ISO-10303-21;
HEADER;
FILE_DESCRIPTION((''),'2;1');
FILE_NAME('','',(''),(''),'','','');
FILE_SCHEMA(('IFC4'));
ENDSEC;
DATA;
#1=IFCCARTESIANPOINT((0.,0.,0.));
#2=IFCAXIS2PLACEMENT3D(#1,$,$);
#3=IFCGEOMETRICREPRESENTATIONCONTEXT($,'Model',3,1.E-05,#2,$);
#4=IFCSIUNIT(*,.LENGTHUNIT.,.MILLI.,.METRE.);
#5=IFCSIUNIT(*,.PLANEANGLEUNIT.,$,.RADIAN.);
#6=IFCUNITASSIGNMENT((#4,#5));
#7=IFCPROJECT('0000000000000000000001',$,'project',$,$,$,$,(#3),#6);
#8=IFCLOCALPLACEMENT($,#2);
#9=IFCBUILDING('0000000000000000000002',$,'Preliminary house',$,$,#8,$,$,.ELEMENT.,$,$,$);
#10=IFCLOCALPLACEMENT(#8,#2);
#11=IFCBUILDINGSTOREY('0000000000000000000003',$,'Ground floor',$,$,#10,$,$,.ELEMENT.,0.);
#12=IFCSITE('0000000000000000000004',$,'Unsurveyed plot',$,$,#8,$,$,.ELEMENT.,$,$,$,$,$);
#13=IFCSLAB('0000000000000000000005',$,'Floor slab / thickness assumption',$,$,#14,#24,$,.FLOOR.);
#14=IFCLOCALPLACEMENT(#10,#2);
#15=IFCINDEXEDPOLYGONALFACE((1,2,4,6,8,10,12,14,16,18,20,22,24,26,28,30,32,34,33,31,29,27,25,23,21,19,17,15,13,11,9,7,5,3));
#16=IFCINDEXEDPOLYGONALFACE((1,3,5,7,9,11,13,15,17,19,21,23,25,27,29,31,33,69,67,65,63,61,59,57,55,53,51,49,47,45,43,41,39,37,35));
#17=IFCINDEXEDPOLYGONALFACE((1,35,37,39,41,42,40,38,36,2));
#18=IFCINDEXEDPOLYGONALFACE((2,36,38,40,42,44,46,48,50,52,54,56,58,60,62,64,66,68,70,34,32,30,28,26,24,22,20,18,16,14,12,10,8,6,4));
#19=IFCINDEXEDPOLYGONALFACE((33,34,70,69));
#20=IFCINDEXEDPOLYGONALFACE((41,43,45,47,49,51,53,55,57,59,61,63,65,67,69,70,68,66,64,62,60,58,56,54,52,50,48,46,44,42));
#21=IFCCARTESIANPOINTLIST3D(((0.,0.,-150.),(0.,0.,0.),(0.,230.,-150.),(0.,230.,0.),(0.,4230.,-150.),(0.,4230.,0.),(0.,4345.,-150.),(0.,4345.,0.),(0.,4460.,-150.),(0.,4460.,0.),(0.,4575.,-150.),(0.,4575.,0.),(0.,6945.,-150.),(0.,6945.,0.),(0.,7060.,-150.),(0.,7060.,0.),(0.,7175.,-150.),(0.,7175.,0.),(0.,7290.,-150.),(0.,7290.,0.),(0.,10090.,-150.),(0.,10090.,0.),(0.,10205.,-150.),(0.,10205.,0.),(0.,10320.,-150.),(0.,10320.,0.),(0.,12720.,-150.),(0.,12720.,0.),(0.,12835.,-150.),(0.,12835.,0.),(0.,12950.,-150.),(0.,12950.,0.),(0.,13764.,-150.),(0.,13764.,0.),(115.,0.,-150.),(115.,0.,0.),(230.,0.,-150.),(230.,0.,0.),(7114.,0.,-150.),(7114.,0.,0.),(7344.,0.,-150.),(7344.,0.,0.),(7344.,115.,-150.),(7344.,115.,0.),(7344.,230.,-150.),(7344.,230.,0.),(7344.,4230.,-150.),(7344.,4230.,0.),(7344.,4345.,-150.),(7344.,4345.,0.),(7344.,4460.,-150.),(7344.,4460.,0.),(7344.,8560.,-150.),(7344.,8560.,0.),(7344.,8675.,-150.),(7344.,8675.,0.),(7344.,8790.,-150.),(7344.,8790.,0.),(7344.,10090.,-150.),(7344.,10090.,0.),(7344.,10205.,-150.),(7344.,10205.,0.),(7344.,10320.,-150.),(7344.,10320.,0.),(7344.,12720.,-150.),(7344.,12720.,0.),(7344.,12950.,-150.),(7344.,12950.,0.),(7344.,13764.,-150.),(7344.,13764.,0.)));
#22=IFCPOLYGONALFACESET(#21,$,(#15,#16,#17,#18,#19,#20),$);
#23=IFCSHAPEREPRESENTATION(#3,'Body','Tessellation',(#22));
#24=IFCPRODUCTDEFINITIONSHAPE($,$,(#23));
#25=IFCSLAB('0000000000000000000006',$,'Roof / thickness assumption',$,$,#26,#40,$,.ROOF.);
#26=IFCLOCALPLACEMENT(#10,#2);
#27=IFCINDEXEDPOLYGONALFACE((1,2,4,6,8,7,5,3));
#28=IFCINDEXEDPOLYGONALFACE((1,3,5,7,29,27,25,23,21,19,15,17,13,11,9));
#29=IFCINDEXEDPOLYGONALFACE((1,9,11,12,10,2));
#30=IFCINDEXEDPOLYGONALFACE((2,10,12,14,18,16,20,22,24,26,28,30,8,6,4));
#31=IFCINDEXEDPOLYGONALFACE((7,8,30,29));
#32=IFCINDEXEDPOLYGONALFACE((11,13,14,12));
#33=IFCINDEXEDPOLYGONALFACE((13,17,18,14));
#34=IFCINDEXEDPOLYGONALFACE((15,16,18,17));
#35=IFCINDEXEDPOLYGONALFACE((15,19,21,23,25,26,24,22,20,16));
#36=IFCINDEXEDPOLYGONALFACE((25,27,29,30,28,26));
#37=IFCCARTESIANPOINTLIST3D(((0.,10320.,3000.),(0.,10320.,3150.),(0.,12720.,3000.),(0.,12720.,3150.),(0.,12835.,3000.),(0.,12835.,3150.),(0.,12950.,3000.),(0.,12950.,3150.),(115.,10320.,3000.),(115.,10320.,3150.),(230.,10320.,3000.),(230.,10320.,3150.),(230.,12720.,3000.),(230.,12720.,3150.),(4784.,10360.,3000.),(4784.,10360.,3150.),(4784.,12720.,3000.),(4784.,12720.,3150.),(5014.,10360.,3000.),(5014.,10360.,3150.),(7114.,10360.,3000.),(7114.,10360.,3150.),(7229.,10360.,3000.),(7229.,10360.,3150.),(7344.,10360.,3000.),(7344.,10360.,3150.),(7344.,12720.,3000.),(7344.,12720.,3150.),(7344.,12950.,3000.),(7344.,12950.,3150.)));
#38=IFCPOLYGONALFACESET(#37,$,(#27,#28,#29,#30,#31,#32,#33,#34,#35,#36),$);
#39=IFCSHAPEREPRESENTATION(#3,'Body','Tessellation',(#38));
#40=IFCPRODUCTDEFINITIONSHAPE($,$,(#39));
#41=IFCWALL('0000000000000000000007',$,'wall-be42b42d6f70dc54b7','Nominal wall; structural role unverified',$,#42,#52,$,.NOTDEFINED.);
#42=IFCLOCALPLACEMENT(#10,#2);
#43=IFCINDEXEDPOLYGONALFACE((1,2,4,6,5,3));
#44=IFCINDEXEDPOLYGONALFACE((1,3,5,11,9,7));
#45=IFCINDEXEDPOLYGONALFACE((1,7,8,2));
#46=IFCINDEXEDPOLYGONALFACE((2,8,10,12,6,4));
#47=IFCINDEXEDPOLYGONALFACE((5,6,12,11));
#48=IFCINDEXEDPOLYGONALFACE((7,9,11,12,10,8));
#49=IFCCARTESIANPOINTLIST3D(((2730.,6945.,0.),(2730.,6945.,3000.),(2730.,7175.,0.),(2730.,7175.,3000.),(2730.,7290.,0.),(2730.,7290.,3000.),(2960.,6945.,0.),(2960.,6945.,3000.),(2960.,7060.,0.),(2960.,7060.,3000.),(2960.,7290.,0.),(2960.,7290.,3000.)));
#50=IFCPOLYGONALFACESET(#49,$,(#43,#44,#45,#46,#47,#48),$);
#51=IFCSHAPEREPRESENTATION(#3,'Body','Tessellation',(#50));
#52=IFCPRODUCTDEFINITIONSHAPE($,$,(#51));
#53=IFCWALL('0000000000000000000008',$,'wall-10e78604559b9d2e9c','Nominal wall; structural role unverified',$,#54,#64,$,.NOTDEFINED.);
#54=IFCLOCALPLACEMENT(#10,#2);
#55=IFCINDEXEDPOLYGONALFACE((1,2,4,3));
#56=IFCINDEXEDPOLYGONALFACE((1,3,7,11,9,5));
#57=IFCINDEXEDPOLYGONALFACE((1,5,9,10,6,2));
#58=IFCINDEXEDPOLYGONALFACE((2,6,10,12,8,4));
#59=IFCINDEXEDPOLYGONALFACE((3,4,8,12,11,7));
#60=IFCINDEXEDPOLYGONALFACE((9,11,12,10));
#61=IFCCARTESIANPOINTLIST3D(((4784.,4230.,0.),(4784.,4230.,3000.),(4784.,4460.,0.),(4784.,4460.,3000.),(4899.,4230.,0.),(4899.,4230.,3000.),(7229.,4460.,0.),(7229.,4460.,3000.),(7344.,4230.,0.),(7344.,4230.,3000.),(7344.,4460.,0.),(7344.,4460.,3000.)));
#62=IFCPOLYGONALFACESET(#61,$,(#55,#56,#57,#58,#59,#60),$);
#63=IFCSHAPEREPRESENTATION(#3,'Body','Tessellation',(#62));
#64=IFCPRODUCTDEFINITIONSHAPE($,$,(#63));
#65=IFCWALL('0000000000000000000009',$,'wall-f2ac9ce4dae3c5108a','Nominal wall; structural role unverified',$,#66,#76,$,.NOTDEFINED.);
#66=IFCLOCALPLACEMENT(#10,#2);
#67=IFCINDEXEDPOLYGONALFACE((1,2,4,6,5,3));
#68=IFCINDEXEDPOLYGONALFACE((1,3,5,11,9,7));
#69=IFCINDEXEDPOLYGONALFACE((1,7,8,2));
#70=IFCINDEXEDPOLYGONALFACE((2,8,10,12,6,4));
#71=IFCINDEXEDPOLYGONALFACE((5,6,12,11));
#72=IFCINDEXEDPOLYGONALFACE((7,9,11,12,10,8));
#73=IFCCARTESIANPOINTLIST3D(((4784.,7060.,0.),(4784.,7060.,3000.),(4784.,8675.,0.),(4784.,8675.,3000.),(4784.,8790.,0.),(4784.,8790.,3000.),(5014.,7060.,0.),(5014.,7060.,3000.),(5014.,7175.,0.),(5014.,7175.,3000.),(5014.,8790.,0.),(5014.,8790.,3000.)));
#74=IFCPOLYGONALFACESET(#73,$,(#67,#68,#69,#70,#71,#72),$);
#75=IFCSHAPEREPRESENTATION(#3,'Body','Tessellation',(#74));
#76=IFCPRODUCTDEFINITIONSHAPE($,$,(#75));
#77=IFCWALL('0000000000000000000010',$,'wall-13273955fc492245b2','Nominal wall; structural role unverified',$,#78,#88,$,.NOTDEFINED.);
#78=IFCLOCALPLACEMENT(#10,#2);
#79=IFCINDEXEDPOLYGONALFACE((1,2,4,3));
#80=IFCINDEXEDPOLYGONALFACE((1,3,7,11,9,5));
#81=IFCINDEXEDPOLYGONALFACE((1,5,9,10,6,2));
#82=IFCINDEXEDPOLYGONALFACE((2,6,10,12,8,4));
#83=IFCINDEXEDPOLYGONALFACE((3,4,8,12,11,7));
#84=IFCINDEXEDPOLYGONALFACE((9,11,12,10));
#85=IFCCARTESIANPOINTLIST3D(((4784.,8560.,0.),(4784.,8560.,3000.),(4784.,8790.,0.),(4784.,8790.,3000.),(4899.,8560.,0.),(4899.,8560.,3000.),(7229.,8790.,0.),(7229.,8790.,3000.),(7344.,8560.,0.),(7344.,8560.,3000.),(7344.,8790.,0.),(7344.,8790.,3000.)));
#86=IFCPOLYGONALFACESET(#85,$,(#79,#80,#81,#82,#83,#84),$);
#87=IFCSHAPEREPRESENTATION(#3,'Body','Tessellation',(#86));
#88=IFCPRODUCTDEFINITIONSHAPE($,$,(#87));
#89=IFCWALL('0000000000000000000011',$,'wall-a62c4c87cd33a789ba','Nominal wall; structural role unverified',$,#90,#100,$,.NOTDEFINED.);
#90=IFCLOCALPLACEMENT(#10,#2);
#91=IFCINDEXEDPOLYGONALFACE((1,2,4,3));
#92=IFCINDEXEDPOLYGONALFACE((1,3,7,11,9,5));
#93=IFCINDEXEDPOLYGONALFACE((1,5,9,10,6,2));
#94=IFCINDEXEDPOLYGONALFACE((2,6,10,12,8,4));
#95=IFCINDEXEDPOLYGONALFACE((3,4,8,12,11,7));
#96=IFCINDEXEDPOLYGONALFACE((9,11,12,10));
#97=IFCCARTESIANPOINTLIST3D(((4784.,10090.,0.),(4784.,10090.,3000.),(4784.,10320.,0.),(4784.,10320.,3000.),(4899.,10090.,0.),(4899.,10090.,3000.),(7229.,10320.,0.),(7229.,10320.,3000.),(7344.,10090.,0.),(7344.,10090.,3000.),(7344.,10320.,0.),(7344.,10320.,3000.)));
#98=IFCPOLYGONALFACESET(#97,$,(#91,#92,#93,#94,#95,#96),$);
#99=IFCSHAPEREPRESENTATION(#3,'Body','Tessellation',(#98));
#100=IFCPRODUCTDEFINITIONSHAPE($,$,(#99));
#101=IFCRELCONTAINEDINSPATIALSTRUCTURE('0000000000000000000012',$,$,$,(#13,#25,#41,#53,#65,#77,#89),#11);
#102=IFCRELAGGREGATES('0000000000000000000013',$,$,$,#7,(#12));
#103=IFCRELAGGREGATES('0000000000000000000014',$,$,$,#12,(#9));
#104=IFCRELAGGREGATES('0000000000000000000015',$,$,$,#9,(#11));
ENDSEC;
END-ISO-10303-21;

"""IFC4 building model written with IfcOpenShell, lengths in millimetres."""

from ifc_helpers import new_model, si_unit, frame, origin, place, context, project, spatial, polyline, outline, extrude, element, save


model = new_model("IFC4")

# Units and contexts
model_context = context("Model", 3, precision=1e-05, world=origin())
ifc_project = project(units=[si_unit("LENGTHUNIT", "METRE", prefix="MILLI"), si_unit("PLANEANGLEUNIT", "RADIAN")], contexts=[model_context])

# Site, building, storey
placement_1 = place(None, origin())
site = spatial("IfcSite", under=ifc_project, at=placement_1, Name="Unsurveyed plot", CompositionType="ELEMENT")
building = spatial("IfcBuilding", under=site, at=placement_1, Name="Preliminary house", CompositionType="ELEMENT")
placement_2 = place(placement_1, origin())
storey = spatial("IfcBuildingStorey", under=building, at=placement_2, Name="Ground floor", CompositionType="ELEMENT", Elevation=0.0)

# Slabs
element("IfcSlab", 1, at=placement_2, inside=storey, Name="Floor slab / thickness assumption", PredefinedType="FLOOR", context=model_context, shape_type="SweptSolid", body=[
    extrude(outline(polyline([(0.0, 0.0), (0.0, 230.0), (0.0, 4230.0), (0.0, 4345.0), (0.0, 4460.0), (0.0, 4575.0), (0.0, 6945.0), (0.0, 7060.0), (0.0, 7175.0), (0.0, 7290.0), (0.0, 10090.0), (0.0, 10205.0), (0.0, 10320.0), (0.0, 12720.0), (0.0, 12835.0), (0.0, 12950.0), (0.0, 13764.0), (7344.0, 13764.0), (7344.0, 12950.0), (7344.0, 12720.0), (7344.0, 10320.0), (7344.0, 10205.0), (7344.0, 10090.0), (7344.0, 8790.0), (7344.0, 8675.0), (7344.0, 8560.0), (7344.0, 4460.0), (7344.0, 4345.0), (7344.0, 4230.0), (7344.0, 230.0), (7344.0, 115.0), (7344.0, 0.0), (7114.0, 0.0), (230.0, 0.0), (115.0, 0.0), (0.0, 0.0)])), frame((0.0, 0.0, -150.0)), (0.0, 0.0, 1.0), 150.0),
])
element("IfcSlab", 2, at=placement_2, inside=storey, Name="Roof / thickness assumption", PredefinedType="ROOF", context=model_context, shape_type="SweptSolid", body=[
    extrude(outline(polyline([(0.0, 12720.0), (0.0, 12835.0), (0.0, 12950.0), (7344.0, 12950.0), (7344.0, 12720.0), (7344.0, 10360.0), (7229.0, 10360.0), (7114.0, 10360.0), (5014.0, 10360.0), (4784.0, 10360.0), (4784.0, 12720.0), (230.0, 12720.0), (230.0, 10320.0), (115.0, 10320.0), (0.0, 10320.0), (0.0, 12720.0)])), frame((0.0, 0.0, 3000.0)), (0.0, 0.0, 1.0), 150.0),
])

# Wall
element("IfcWall", 3, at=placement_2, inside=storey, Name="wall-be42b42d6f70dc54b7", Description="Nominal wall; structural role unverified", PredefinedType="NOTDEFINED", context=model_context, shape_type="SweptSolid", body=[
    extrude(outline(polyline([(2730.0, 7175.0), (2730.0, 7290.0), (2960.0, 7290.0), (2960.0, 7060.0), (2960.0, 6945.0), (2730.0, 6945.0), (2730.0, 7175.0)])), origin(), (0.0, 0.0, 1.0), 3000.0),
])

# Walls
element("IfcWall", 4, at=placement_2, inside=storey, Name="wall-10e78604559b9d2e9c", Description="Nominal wall; structural role unverified", PredefinedType="NOTDEFINED", context=model_context, shape_type="SweptSolid", body=[
    extrude(outline(polyline([(7229.0, 4460.0), (7344.0, 4460.0), (7344.0, 4230.0), (4899.0, 4230.0), (4784.0, 4230.0), (4784.0, 4460.0), (7229.0, 4460.0)])), origin(), (0.0, 0.0, 1.0), 3000.0),
])
element("IfcWall", 5, at=placement_2, inside=storey, Name="wall-f2ac9ce4dae3c5108a", Description="Nominal wall; structural role unverified", PredefinedType="NOTDEFINED", context=model_context, shape_type="SweptSolid", body=[
    extrude(outline(polyline([(4784.0, 8675.0), (4784.0, 8790.0), (5014.0, 8790.0), (5014.0, 7175.0), (5014.0, 7060.0), (4784.0, 7060.0), (4784.0, 8675.0)])), origin(), (0.0, 0.0, 1.0), 3000.0),
])

# Wall
element("IfcWall", 6, at=placement_2, inside=storey, Name="wall-13273955fc492245b2", Description="Nominal wall; structural role unverified", PredefinedType="NOTDEFINED", context=model_context, shape_type="SweptSolid", body=[
    extrude(outline(polyline([(7229.0, 8790.0), (7344.0, 8790.0), (7344.0, 8560.0), (4899.0, 8560.0), (4784.0, 8560.0), (4784.0, 8790.0), (7229.0, 8790.0)])), origin(), (0.0, 0.0, 1.0), 3000.0),
])

# Wall
element("IfcWall", 7, at=placement_2, inside=storey, Name="wall-a62c4c87cd33a789ba", Description="Nominal wall; structural role unverified", PredefinedType="NOTDEFINED", context=model_context, shape_type="SweptSolid", body=[
    extrude(outline(polyline([(7229.0, 10320.0), (7344.0, 10320.0), (7344.0, 10090.0), (4899.0, 10090.0), (4784.0, 10090.0), (4784.0, 10320.0), (7229.0, 10320.0)])), origin(), (0.0, 0.0, 1.0), 3000.0),
])

save(model, "model.ifc")
